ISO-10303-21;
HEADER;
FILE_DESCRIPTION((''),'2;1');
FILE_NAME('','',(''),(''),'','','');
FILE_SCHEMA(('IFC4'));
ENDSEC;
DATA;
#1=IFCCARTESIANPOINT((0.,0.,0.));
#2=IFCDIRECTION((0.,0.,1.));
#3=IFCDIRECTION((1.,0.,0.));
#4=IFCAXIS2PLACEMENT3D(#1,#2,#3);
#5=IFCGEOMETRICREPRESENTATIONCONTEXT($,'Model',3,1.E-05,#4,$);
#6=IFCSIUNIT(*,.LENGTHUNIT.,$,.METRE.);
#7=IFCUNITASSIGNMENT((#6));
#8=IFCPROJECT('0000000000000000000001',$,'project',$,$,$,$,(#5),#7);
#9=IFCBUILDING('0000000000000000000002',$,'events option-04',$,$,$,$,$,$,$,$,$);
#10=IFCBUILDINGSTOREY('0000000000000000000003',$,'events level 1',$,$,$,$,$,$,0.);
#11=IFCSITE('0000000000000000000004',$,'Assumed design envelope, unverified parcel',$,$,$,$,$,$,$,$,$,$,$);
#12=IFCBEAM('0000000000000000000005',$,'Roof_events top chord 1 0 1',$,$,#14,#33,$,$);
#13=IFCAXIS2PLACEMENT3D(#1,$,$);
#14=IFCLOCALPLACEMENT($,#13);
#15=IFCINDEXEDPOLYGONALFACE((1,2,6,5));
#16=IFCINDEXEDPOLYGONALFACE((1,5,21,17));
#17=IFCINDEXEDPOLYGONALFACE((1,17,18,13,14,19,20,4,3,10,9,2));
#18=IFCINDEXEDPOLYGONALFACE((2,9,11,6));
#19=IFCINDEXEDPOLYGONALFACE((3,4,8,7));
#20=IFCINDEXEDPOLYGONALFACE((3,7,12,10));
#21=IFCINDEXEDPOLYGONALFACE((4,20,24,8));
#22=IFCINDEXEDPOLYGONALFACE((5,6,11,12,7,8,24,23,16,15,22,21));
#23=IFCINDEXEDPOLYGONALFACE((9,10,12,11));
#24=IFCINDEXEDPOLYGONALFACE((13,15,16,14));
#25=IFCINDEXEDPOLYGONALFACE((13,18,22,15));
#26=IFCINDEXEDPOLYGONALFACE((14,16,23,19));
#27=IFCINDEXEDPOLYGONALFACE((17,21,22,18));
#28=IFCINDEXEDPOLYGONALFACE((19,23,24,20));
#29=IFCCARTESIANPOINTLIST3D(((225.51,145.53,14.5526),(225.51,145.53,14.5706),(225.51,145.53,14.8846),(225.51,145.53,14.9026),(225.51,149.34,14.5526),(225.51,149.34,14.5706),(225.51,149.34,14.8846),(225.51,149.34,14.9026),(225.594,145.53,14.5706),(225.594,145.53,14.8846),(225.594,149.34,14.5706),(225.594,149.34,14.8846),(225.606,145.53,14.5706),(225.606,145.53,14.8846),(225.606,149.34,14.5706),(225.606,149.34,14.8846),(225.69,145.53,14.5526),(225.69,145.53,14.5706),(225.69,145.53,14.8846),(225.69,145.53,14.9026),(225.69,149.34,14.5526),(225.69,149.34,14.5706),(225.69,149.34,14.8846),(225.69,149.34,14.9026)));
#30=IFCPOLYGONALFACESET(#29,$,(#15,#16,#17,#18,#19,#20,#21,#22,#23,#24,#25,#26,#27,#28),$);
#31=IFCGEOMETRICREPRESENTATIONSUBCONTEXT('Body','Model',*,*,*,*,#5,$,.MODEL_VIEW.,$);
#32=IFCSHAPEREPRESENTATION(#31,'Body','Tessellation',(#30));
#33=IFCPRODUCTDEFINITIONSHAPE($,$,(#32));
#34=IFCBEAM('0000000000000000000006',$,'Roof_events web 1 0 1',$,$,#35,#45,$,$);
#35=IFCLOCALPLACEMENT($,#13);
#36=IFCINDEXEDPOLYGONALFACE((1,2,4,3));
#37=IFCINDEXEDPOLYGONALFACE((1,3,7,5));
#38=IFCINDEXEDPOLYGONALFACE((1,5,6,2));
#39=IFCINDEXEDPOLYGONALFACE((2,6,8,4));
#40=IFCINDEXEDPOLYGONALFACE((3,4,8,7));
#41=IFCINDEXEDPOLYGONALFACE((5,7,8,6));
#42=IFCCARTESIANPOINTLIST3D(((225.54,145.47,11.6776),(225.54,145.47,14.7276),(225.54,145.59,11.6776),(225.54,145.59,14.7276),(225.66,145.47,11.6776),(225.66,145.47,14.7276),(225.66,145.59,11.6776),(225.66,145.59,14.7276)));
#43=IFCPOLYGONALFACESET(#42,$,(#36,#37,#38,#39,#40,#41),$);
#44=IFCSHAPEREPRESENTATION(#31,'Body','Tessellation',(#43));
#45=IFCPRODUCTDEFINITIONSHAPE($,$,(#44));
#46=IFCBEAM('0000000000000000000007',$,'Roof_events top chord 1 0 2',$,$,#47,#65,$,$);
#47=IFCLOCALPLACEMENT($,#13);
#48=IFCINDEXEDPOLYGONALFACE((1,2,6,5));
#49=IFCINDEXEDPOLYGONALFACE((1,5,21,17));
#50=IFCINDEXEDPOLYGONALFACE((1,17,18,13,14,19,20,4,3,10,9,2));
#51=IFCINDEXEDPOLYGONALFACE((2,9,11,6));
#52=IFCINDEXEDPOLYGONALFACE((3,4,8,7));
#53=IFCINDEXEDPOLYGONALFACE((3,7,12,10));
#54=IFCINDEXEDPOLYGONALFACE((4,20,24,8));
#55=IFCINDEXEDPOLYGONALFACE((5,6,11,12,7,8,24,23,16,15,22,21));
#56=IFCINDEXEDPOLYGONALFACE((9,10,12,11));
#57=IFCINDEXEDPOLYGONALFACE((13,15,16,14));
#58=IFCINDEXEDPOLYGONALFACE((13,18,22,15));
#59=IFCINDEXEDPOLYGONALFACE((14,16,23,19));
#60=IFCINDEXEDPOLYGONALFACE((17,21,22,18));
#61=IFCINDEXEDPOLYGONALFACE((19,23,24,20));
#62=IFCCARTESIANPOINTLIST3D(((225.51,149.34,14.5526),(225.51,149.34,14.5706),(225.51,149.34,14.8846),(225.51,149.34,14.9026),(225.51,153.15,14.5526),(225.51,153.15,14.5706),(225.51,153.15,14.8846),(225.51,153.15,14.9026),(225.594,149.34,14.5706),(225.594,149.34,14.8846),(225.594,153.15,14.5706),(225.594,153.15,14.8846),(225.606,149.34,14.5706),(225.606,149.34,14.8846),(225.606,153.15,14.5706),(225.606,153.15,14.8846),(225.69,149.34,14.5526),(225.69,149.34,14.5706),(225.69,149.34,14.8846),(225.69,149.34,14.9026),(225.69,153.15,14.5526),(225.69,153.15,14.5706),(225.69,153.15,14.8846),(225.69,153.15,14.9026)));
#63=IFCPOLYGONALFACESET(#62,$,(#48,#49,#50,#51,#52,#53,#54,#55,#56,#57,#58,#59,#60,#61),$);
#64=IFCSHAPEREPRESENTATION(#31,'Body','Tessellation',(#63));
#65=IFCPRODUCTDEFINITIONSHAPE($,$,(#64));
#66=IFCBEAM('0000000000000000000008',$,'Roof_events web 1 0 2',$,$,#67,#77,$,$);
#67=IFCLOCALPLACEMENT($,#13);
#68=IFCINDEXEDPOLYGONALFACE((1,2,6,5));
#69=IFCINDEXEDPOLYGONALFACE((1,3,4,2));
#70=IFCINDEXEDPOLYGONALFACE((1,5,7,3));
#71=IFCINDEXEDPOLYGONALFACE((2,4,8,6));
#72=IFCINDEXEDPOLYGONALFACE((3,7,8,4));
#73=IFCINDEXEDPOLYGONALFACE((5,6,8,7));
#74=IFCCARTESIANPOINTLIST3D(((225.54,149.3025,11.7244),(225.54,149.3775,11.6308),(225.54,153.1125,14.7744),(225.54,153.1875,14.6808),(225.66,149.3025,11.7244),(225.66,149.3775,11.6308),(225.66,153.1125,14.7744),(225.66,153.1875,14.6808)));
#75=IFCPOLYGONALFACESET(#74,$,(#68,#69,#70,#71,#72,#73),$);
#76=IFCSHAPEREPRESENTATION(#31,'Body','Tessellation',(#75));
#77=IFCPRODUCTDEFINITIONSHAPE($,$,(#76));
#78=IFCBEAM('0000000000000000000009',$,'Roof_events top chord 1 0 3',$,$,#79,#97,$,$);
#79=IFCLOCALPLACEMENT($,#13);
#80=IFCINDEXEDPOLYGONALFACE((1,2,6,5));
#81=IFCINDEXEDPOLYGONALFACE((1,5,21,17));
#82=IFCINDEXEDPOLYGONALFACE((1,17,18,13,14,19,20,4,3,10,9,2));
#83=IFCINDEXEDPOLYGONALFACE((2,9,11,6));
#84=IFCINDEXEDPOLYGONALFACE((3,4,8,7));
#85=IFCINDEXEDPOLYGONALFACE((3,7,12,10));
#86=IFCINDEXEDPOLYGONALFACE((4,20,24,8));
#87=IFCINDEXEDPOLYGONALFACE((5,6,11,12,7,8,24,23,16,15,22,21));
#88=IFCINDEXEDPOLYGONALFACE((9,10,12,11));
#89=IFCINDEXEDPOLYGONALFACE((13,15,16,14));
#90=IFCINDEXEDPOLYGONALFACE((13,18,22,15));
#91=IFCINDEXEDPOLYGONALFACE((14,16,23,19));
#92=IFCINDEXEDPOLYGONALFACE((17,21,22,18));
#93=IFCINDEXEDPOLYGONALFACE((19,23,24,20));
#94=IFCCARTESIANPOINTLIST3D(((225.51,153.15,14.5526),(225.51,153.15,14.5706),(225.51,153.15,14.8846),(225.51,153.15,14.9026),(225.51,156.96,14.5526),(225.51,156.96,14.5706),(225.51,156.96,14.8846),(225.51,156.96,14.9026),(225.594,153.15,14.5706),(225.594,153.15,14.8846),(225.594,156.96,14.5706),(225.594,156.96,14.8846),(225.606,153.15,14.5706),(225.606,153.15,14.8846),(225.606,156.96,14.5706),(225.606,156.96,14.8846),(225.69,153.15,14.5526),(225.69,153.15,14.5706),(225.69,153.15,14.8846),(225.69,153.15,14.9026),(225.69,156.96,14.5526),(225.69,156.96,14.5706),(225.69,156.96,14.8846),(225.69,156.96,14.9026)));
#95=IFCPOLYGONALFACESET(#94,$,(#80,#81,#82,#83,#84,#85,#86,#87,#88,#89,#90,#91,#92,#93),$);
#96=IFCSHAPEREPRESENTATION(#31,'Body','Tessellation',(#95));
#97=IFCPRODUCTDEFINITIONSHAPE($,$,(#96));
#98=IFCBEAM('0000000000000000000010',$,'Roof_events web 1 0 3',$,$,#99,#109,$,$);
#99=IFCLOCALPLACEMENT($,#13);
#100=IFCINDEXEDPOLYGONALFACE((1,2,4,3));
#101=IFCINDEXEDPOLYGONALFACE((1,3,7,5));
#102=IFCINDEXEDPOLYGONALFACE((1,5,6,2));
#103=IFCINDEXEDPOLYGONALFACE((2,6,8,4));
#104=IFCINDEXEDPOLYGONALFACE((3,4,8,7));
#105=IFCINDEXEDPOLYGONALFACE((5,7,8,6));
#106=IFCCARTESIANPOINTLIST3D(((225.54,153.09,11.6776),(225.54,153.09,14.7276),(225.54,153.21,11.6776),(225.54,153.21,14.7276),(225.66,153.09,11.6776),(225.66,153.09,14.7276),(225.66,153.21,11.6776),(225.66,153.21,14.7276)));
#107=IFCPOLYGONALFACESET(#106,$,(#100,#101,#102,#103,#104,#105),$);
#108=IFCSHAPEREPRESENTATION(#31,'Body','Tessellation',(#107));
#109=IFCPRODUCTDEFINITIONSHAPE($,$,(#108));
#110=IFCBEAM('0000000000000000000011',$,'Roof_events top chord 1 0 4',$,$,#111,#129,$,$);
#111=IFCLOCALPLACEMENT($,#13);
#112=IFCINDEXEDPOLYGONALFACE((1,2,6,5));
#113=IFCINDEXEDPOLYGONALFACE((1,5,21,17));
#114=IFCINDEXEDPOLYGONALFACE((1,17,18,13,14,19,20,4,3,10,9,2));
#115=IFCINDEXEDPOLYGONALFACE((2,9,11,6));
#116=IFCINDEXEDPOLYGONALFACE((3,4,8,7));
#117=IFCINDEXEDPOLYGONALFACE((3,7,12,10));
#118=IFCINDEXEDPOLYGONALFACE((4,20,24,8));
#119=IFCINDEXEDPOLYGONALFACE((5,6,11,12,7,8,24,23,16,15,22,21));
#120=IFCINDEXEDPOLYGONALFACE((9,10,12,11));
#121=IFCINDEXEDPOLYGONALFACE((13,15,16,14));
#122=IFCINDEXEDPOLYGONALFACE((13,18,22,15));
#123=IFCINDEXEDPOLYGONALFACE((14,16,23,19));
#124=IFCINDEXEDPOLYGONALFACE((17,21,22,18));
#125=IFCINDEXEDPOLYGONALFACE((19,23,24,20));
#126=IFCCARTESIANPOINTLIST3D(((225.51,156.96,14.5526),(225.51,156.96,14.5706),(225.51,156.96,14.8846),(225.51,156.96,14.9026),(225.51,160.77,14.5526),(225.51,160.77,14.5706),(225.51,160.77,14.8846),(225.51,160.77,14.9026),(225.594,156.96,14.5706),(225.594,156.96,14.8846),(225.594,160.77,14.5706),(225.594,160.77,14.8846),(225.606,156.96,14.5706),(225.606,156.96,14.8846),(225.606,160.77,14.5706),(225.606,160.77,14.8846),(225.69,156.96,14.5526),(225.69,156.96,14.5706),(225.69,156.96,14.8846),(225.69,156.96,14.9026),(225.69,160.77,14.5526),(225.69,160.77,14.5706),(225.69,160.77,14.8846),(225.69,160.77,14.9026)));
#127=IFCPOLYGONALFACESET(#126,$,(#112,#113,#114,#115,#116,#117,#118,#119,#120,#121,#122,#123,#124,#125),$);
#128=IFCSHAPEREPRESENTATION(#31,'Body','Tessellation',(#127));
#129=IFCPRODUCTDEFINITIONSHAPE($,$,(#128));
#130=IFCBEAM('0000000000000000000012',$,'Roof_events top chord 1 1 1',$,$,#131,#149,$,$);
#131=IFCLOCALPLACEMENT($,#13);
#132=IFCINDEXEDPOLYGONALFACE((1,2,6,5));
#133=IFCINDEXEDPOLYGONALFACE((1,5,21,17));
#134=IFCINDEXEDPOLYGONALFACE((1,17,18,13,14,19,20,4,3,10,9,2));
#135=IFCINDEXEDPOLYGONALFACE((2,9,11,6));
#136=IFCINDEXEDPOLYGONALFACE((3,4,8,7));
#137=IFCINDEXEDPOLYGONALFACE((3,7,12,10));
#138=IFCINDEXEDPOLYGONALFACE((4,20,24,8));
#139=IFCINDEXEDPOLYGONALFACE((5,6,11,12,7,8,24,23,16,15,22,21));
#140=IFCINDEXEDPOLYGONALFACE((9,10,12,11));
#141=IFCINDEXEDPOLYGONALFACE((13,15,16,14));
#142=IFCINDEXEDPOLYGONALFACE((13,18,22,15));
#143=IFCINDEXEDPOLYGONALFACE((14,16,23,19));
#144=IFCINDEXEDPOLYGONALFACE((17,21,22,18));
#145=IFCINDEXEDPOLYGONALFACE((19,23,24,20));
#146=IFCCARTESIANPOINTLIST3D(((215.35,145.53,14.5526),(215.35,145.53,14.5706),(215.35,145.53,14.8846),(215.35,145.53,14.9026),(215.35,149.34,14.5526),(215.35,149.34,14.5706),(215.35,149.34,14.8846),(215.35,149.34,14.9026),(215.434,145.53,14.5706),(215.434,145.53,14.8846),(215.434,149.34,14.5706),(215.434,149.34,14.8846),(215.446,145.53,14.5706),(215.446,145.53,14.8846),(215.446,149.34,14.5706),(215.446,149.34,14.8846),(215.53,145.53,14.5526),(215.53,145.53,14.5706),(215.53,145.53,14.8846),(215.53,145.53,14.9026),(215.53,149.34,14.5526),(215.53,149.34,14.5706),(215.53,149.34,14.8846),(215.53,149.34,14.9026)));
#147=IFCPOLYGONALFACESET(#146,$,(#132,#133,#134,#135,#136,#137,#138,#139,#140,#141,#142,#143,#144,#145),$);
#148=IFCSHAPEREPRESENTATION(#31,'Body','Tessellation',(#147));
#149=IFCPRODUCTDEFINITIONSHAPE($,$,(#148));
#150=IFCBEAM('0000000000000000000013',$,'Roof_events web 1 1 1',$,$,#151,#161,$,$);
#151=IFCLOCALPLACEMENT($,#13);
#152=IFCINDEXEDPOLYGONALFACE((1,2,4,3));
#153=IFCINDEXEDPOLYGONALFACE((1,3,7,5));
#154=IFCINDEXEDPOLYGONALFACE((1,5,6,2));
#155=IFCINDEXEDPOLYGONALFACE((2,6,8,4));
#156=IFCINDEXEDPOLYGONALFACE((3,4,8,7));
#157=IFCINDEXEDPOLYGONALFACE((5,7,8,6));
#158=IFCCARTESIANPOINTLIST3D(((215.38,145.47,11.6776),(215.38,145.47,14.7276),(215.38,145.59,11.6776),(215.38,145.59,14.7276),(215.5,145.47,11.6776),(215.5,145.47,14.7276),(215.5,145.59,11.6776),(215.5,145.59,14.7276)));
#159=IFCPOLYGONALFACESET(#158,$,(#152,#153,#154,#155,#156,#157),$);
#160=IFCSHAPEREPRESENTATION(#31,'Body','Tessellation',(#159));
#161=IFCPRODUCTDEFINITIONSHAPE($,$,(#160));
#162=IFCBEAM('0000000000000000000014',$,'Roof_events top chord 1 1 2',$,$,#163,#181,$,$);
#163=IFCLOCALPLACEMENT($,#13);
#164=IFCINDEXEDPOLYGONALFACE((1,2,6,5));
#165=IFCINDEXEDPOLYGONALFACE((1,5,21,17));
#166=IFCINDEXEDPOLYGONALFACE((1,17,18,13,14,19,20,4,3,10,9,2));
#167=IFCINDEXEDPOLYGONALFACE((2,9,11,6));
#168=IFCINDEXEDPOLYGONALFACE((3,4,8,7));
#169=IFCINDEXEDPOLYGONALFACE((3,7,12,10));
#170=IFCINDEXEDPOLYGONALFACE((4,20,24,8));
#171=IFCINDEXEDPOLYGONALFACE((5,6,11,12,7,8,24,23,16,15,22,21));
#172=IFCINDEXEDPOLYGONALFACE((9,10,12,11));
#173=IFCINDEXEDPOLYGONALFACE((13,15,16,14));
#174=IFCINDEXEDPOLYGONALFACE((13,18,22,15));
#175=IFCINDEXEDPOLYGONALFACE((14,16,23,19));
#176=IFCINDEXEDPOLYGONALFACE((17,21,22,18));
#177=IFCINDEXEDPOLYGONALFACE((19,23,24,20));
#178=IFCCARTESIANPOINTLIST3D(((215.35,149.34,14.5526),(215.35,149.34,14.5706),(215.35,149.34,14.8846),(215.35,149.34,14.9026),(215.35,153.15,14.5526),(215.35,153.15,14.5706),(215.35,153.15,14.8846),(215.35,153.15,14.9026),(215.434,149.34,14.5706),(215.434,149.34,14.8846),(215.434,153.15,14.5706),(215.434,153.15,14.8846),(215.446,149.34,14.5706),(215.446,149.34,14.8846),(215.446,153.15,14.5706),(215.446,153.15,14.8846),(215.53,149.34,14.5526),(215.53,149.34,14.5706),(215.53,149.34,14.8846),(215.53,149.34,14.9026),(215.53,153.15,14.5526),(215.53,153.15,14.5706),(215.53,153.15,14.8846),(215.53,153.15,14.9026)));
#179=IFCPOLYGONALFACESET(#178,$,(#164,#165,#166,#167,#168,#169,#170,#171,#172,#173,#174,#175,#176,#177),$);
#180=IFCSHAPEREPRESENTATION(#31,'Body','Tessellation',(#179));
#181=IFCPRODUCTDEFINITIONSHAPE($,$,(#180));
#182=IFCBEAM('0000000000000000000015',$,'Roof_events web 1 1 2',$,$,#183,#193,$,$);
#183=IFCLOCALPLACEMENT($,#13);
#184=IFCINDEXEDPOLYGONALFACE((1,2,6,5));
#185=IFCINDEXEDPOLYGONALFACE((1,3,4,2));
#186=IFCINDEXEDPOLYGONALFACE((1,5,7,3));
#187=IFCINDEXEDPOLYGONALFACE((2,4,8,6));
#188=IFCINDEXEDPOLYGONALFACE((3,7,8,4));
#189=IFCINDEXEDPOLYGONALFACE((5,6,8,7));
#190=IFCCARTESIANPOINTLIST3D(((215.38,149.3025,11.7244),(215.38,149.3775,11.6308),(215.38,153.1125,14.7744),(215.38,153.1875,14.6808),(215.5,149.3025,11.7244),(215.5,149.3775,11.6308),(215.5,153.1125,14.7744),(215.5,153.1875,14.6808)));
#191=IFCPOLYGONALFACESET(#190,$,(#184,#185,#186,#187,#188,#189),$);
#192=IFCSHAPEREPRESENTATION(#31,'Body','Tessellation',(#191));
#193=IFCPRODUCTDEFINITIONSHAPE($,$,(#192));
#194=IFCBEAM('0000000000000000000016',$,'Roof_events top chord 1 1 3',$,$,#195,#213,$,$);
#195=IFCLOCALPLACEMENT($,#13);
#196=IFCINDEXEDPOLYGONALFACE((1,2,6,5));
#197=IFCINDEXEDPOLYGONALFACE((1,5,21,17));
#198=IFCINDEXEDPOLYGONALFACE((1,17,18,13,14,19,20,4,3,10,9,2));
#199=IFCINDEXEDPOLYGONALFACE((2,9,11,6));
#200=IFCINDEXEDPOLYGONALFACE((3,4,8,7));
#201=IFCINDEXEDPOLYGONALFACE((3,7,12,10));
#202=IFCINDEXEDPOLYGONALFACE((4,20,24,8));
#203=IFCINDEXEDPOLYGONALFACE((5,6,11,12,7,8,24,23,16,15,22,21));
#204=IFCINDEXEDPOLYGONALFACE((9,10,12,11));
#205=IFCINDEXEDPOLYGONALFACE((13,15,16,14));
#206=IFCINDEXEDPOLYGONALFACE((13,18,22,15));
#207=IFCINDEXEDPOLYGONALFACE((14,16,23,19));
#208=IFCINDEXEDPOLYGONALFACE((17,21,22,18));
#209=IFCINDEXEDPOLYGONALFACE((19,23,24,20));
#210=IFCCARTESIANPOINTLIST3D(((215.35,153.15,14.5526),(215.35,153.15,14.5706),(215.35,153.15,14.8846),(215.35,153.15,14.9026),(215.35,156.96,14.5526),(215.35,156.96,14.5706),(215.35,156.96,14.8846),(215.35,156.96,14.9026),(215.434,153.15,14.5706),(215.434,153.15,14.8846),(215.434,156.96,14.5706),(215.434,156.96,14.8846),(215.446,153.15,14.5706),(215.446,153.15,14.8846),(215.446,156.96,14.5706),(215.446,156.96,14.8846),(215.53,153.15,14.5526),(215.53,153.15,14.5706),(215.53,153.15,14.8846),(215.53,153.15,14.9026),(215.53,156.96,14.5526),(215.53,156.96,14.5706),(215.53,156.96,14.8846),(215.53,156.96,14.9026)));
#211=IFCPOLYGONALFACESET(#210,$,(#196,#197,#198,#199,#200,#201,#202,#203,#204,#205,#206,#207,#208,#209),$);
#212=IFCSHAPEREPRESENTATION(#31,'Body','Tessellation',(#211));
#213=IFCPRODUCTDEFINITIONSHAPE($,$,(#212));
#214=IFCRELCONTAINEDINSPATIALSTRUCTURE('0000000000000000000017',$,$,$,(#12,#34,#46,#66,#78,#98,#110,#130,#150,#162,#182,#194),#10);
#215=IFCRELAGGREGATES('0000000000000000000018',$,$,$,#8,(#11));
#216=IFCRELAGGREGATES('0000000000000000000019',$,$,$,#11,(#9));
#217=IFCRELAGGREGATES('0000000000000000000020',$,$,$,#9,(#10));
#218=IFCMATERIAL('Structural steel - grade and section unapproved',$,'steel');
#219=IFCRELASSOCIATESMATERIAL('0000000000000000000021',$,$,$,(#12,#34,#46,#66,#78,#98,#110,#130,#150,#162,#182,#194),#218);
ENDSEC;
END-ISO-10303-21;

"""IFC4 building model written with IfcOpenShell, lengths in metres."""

from ifc_helpers import new_model, si_unit, frame, origin_with_axes, place, context, subcontext, project, spatial, rectangle, i_section, extrude, material, element, save


model = new_model("IFC4")

# Units and contexts
model_context = context("Model", 3, precision=1e-05, world=origin_with_axes())
body_context = subcontext(model_context, "Body", "Model", "MODEL_VIEW")
ifc_project = project(units=[si_unit("LENGTHUNIT", "METRE")], contexts=[model_context])

# Site, building, storey
site = spatial("IfcSite", under=ifc_project, Name="Assumed design envelope, unverified parcel")
building = spatial("IfcBuilding", under=site, Name="events option-04")
storey = spatial("IfcBuildingStorey", under=building, Name="events level 1", Elevation=0.0)

# Beams
ifc_material = material(Name="Structural steel - grade and section unapproved", Category="steel")
beam_1_placement = place(None, frame((225.6, 145.53, 14.7276), z_axis=(0.0, 1.0, 0.0), x_axis=(-1.0, 0.0, 0.0)))
element("IfcBeam", 1, at=beam_1_placement, inside=storey, material=ifc_material, Name="Roof_events top chord 1 0 1", context=body_context, shape_type="SweptSolid", body=[
    extrude(i_section(OverallWidth=0.18, OverallDepth=0.35, WebThickness=0.012, FlangeThickness=0.018, FilletRadius=0.0), origin_with_axes(), (0.0, 0.0, 1.0), 3.81),
])
beam_2_placement = place(None, frame((225.6, 145.53, 11.6776), z_axis=(0.0, 0.0, 1.0), x_axis=(-1.0, 0.0, 0.0)))
element("IfcBeam", 2, at=beam_2_placement, inside=storey, material=ifc_material, Name="Roof_events web 1 0 1", context=body_context, shape_type="SweptSolid", body=[
    extrude(rectangle(XDim=0.12, YDim=0.12), origin_with_axes(), (0.0, 0.0, 1.0), 3.05),
])
beam_3_placement = place(None, frame((225.6, 149.34, 14.7276), z_axis=(0.0, 1.0, 0.0), x_axis=(-1.0, 0.0, 0.0)))
element("IfcBeam", 3, at=beam_3_placement, inside=storey, material=ifc_material, Name="Roof_events top chord 1 0 2", context=body_context, shape_type="SweptSolid", body=[
    extrude(i_section(OverallWidth=0.18, OverallDepth=0.35, WebThickness=0.012, FlangeThickness=0.018, FilletRadius=0.0), origin_with_axes(), (0.0, 0.0, 1.0), 3.81),
])
beam_4_placement = place(None, frame((225.6, 149.34, 11.6776), z_axis=(0.0, 0.780669, 0.624945), x_axis=(-1.0, 0.0, 0.0)))
element("IfcBeam", 4, at=beam_4_placement, inside=storey, material=ifc_material, Name="Roof_events web 1 0 2", context=body_context, shape_type="SweptSolid", body=[
    extrude(rectangle(XDim=0.12, YDim=0.12), origin_with_axes(), (0.0, 0.0, 1.0), 4.8804),
])
beam_5_placement = place(None, frame((225.6, 153.15, 14.7276), z_axis=(0.0, 1.0, 0.0), x_axis=(-1.0, 0.0, 0.0)))
element("IfcBeam", 5, at=beam_5_placement, inside=storey, material=ifc_material, Name="Roof_events top chord 1 0 3", context=body_context, shape_type="SweptSolid", body=[
    extrude(i_section(OverallWidth=0.18, OverallDepth=0.35, WebThickness=0.012, FlangeThickness=0.018, FilletRadius=0.0), origin_with_axes(), (0.0, 0.0, 1.0), 3.81),
])
beam_6_placement = place(None, frame((225.6, 153.15, 11.6776), z_axis=(0.0, 0.0, 1.0), x_axis=(-1.0, 0.0, 0.0)))
element("IfcBeam", 6, at=beam_6_placement, inside=storey, material=ifc_material, Name="Roof_events web 1 0 3", context=body_context, shape_type="SweptSolid", body=[
    extrude(rectangle(XDim=0.12, YDim=0.12), origin_with_axes(), (0.0, 0.0, 1.0), 3.05),
])
for number, where, z_axis, x_axis, name in (
    (7, (225.6, 156.96, 14.7276), (0.0, 1.0, 0.0), (-1.0, 0.0, 0.0), "Roof_events top chord 1 0 4"),
    (8, (215.44, 145.53, 14.7276), (0.0, 1.0, 0.0), (-1.0, 0.0, 0.0), "Roof_events top chord 1 1 1"),
):
    element("IfcBeam", number, at=place(None, frame(where, z_axis=z_axis, x_axis=x_axis)), inside=storey, material=ifc_material, Name=name, context=body_context, shape_type="SweptSolid", body=[
        extrude(i_section(OverallWidth=0.18, OverallDepth=0.35, WebThickness=0.012, FlangeThickness=0.018, FilletRadius=0.0), origin_with_axes(), (0.0, 0.0, 1.0), 3.81),
    ])
beam_7_placement = place(None, frame((215.44, 145.53, 11.6776), z_axis=(0.0, 0.0, 1.0), x_axis=(-1.0, 0.0, 0.0)))
element("IfcBeam", 9, at=beam_7_placement, inside=storey, material=ifc_material, Name="Roof_events web 1 1 1", context=body_context, shape_type="SweptSolid", body=[
    extrude(rectangle(XDim=0.12, YDim=0.12), origin_with_axes(), (0.0, 0.0, 1.0), 3.05),
])
beam_8_placement = place(None, frame((215.44, 149.34, 14.7276), z_axis=(0.0, 1.0, 0.0), x_axis=(-1.0, 0.0, 0.0)))
element("IfcBeam", 10, at=beam_8_placement, inside=storey, material=ifc_material, Name="Roof_events top chord 1 1 2", context=body_context, shape_type="SweptSolid", body=[
    extrude(i_section(OverallWidth=0.18, OverallDepth=0.35, WebThickness=0.012, FlangeThickness=0.018, FilletRadius=0.0), origin_with_axes(), (0.0, 0.0, 1.0), 3.81),
])
beam_9_placement = place(None, frame((215.44, 149.34, 11.6776), z_axis=(0.0, 0.780669, 0.624945), x_axis=(-1.0, 0.0, 0.0)))
element("IfcBeam", 11, at=beam_9_placement, inside=storey, material=ifc_material, Name="Roof_events web 1 1 2", context=body_context, shape_type="SweptSolid", body=[
    extrude(rectangle(XDim=0.12, YDim=0.12), origin_with_axes(), (0.0, 0.0, 1.0), 4.8804),
])
beam_10_placement = place(None, frame((215.44, 153.15, 14.7276), z_axis=(0.0, 1.0, 0.0), x_axis=(-1.0, 0.0, 0.0)))
element("IfcBeam", 12, at=beam_10_placement, inside=storey, material=ifc_material, Name="Roof_events top chord 1 1 3", context=body_context, shape_type="SweptSolid", body=[
    extrude(i_section(OverallWidth=0.18, OverallDepth=0.35, WebThickness=0.012, FlangeThickness=0.018, FilletRadius=0.0), origin_with_axes(), (0.0, 0.0, 1.0), 3.81),
])

save(model, "model.ifc")
